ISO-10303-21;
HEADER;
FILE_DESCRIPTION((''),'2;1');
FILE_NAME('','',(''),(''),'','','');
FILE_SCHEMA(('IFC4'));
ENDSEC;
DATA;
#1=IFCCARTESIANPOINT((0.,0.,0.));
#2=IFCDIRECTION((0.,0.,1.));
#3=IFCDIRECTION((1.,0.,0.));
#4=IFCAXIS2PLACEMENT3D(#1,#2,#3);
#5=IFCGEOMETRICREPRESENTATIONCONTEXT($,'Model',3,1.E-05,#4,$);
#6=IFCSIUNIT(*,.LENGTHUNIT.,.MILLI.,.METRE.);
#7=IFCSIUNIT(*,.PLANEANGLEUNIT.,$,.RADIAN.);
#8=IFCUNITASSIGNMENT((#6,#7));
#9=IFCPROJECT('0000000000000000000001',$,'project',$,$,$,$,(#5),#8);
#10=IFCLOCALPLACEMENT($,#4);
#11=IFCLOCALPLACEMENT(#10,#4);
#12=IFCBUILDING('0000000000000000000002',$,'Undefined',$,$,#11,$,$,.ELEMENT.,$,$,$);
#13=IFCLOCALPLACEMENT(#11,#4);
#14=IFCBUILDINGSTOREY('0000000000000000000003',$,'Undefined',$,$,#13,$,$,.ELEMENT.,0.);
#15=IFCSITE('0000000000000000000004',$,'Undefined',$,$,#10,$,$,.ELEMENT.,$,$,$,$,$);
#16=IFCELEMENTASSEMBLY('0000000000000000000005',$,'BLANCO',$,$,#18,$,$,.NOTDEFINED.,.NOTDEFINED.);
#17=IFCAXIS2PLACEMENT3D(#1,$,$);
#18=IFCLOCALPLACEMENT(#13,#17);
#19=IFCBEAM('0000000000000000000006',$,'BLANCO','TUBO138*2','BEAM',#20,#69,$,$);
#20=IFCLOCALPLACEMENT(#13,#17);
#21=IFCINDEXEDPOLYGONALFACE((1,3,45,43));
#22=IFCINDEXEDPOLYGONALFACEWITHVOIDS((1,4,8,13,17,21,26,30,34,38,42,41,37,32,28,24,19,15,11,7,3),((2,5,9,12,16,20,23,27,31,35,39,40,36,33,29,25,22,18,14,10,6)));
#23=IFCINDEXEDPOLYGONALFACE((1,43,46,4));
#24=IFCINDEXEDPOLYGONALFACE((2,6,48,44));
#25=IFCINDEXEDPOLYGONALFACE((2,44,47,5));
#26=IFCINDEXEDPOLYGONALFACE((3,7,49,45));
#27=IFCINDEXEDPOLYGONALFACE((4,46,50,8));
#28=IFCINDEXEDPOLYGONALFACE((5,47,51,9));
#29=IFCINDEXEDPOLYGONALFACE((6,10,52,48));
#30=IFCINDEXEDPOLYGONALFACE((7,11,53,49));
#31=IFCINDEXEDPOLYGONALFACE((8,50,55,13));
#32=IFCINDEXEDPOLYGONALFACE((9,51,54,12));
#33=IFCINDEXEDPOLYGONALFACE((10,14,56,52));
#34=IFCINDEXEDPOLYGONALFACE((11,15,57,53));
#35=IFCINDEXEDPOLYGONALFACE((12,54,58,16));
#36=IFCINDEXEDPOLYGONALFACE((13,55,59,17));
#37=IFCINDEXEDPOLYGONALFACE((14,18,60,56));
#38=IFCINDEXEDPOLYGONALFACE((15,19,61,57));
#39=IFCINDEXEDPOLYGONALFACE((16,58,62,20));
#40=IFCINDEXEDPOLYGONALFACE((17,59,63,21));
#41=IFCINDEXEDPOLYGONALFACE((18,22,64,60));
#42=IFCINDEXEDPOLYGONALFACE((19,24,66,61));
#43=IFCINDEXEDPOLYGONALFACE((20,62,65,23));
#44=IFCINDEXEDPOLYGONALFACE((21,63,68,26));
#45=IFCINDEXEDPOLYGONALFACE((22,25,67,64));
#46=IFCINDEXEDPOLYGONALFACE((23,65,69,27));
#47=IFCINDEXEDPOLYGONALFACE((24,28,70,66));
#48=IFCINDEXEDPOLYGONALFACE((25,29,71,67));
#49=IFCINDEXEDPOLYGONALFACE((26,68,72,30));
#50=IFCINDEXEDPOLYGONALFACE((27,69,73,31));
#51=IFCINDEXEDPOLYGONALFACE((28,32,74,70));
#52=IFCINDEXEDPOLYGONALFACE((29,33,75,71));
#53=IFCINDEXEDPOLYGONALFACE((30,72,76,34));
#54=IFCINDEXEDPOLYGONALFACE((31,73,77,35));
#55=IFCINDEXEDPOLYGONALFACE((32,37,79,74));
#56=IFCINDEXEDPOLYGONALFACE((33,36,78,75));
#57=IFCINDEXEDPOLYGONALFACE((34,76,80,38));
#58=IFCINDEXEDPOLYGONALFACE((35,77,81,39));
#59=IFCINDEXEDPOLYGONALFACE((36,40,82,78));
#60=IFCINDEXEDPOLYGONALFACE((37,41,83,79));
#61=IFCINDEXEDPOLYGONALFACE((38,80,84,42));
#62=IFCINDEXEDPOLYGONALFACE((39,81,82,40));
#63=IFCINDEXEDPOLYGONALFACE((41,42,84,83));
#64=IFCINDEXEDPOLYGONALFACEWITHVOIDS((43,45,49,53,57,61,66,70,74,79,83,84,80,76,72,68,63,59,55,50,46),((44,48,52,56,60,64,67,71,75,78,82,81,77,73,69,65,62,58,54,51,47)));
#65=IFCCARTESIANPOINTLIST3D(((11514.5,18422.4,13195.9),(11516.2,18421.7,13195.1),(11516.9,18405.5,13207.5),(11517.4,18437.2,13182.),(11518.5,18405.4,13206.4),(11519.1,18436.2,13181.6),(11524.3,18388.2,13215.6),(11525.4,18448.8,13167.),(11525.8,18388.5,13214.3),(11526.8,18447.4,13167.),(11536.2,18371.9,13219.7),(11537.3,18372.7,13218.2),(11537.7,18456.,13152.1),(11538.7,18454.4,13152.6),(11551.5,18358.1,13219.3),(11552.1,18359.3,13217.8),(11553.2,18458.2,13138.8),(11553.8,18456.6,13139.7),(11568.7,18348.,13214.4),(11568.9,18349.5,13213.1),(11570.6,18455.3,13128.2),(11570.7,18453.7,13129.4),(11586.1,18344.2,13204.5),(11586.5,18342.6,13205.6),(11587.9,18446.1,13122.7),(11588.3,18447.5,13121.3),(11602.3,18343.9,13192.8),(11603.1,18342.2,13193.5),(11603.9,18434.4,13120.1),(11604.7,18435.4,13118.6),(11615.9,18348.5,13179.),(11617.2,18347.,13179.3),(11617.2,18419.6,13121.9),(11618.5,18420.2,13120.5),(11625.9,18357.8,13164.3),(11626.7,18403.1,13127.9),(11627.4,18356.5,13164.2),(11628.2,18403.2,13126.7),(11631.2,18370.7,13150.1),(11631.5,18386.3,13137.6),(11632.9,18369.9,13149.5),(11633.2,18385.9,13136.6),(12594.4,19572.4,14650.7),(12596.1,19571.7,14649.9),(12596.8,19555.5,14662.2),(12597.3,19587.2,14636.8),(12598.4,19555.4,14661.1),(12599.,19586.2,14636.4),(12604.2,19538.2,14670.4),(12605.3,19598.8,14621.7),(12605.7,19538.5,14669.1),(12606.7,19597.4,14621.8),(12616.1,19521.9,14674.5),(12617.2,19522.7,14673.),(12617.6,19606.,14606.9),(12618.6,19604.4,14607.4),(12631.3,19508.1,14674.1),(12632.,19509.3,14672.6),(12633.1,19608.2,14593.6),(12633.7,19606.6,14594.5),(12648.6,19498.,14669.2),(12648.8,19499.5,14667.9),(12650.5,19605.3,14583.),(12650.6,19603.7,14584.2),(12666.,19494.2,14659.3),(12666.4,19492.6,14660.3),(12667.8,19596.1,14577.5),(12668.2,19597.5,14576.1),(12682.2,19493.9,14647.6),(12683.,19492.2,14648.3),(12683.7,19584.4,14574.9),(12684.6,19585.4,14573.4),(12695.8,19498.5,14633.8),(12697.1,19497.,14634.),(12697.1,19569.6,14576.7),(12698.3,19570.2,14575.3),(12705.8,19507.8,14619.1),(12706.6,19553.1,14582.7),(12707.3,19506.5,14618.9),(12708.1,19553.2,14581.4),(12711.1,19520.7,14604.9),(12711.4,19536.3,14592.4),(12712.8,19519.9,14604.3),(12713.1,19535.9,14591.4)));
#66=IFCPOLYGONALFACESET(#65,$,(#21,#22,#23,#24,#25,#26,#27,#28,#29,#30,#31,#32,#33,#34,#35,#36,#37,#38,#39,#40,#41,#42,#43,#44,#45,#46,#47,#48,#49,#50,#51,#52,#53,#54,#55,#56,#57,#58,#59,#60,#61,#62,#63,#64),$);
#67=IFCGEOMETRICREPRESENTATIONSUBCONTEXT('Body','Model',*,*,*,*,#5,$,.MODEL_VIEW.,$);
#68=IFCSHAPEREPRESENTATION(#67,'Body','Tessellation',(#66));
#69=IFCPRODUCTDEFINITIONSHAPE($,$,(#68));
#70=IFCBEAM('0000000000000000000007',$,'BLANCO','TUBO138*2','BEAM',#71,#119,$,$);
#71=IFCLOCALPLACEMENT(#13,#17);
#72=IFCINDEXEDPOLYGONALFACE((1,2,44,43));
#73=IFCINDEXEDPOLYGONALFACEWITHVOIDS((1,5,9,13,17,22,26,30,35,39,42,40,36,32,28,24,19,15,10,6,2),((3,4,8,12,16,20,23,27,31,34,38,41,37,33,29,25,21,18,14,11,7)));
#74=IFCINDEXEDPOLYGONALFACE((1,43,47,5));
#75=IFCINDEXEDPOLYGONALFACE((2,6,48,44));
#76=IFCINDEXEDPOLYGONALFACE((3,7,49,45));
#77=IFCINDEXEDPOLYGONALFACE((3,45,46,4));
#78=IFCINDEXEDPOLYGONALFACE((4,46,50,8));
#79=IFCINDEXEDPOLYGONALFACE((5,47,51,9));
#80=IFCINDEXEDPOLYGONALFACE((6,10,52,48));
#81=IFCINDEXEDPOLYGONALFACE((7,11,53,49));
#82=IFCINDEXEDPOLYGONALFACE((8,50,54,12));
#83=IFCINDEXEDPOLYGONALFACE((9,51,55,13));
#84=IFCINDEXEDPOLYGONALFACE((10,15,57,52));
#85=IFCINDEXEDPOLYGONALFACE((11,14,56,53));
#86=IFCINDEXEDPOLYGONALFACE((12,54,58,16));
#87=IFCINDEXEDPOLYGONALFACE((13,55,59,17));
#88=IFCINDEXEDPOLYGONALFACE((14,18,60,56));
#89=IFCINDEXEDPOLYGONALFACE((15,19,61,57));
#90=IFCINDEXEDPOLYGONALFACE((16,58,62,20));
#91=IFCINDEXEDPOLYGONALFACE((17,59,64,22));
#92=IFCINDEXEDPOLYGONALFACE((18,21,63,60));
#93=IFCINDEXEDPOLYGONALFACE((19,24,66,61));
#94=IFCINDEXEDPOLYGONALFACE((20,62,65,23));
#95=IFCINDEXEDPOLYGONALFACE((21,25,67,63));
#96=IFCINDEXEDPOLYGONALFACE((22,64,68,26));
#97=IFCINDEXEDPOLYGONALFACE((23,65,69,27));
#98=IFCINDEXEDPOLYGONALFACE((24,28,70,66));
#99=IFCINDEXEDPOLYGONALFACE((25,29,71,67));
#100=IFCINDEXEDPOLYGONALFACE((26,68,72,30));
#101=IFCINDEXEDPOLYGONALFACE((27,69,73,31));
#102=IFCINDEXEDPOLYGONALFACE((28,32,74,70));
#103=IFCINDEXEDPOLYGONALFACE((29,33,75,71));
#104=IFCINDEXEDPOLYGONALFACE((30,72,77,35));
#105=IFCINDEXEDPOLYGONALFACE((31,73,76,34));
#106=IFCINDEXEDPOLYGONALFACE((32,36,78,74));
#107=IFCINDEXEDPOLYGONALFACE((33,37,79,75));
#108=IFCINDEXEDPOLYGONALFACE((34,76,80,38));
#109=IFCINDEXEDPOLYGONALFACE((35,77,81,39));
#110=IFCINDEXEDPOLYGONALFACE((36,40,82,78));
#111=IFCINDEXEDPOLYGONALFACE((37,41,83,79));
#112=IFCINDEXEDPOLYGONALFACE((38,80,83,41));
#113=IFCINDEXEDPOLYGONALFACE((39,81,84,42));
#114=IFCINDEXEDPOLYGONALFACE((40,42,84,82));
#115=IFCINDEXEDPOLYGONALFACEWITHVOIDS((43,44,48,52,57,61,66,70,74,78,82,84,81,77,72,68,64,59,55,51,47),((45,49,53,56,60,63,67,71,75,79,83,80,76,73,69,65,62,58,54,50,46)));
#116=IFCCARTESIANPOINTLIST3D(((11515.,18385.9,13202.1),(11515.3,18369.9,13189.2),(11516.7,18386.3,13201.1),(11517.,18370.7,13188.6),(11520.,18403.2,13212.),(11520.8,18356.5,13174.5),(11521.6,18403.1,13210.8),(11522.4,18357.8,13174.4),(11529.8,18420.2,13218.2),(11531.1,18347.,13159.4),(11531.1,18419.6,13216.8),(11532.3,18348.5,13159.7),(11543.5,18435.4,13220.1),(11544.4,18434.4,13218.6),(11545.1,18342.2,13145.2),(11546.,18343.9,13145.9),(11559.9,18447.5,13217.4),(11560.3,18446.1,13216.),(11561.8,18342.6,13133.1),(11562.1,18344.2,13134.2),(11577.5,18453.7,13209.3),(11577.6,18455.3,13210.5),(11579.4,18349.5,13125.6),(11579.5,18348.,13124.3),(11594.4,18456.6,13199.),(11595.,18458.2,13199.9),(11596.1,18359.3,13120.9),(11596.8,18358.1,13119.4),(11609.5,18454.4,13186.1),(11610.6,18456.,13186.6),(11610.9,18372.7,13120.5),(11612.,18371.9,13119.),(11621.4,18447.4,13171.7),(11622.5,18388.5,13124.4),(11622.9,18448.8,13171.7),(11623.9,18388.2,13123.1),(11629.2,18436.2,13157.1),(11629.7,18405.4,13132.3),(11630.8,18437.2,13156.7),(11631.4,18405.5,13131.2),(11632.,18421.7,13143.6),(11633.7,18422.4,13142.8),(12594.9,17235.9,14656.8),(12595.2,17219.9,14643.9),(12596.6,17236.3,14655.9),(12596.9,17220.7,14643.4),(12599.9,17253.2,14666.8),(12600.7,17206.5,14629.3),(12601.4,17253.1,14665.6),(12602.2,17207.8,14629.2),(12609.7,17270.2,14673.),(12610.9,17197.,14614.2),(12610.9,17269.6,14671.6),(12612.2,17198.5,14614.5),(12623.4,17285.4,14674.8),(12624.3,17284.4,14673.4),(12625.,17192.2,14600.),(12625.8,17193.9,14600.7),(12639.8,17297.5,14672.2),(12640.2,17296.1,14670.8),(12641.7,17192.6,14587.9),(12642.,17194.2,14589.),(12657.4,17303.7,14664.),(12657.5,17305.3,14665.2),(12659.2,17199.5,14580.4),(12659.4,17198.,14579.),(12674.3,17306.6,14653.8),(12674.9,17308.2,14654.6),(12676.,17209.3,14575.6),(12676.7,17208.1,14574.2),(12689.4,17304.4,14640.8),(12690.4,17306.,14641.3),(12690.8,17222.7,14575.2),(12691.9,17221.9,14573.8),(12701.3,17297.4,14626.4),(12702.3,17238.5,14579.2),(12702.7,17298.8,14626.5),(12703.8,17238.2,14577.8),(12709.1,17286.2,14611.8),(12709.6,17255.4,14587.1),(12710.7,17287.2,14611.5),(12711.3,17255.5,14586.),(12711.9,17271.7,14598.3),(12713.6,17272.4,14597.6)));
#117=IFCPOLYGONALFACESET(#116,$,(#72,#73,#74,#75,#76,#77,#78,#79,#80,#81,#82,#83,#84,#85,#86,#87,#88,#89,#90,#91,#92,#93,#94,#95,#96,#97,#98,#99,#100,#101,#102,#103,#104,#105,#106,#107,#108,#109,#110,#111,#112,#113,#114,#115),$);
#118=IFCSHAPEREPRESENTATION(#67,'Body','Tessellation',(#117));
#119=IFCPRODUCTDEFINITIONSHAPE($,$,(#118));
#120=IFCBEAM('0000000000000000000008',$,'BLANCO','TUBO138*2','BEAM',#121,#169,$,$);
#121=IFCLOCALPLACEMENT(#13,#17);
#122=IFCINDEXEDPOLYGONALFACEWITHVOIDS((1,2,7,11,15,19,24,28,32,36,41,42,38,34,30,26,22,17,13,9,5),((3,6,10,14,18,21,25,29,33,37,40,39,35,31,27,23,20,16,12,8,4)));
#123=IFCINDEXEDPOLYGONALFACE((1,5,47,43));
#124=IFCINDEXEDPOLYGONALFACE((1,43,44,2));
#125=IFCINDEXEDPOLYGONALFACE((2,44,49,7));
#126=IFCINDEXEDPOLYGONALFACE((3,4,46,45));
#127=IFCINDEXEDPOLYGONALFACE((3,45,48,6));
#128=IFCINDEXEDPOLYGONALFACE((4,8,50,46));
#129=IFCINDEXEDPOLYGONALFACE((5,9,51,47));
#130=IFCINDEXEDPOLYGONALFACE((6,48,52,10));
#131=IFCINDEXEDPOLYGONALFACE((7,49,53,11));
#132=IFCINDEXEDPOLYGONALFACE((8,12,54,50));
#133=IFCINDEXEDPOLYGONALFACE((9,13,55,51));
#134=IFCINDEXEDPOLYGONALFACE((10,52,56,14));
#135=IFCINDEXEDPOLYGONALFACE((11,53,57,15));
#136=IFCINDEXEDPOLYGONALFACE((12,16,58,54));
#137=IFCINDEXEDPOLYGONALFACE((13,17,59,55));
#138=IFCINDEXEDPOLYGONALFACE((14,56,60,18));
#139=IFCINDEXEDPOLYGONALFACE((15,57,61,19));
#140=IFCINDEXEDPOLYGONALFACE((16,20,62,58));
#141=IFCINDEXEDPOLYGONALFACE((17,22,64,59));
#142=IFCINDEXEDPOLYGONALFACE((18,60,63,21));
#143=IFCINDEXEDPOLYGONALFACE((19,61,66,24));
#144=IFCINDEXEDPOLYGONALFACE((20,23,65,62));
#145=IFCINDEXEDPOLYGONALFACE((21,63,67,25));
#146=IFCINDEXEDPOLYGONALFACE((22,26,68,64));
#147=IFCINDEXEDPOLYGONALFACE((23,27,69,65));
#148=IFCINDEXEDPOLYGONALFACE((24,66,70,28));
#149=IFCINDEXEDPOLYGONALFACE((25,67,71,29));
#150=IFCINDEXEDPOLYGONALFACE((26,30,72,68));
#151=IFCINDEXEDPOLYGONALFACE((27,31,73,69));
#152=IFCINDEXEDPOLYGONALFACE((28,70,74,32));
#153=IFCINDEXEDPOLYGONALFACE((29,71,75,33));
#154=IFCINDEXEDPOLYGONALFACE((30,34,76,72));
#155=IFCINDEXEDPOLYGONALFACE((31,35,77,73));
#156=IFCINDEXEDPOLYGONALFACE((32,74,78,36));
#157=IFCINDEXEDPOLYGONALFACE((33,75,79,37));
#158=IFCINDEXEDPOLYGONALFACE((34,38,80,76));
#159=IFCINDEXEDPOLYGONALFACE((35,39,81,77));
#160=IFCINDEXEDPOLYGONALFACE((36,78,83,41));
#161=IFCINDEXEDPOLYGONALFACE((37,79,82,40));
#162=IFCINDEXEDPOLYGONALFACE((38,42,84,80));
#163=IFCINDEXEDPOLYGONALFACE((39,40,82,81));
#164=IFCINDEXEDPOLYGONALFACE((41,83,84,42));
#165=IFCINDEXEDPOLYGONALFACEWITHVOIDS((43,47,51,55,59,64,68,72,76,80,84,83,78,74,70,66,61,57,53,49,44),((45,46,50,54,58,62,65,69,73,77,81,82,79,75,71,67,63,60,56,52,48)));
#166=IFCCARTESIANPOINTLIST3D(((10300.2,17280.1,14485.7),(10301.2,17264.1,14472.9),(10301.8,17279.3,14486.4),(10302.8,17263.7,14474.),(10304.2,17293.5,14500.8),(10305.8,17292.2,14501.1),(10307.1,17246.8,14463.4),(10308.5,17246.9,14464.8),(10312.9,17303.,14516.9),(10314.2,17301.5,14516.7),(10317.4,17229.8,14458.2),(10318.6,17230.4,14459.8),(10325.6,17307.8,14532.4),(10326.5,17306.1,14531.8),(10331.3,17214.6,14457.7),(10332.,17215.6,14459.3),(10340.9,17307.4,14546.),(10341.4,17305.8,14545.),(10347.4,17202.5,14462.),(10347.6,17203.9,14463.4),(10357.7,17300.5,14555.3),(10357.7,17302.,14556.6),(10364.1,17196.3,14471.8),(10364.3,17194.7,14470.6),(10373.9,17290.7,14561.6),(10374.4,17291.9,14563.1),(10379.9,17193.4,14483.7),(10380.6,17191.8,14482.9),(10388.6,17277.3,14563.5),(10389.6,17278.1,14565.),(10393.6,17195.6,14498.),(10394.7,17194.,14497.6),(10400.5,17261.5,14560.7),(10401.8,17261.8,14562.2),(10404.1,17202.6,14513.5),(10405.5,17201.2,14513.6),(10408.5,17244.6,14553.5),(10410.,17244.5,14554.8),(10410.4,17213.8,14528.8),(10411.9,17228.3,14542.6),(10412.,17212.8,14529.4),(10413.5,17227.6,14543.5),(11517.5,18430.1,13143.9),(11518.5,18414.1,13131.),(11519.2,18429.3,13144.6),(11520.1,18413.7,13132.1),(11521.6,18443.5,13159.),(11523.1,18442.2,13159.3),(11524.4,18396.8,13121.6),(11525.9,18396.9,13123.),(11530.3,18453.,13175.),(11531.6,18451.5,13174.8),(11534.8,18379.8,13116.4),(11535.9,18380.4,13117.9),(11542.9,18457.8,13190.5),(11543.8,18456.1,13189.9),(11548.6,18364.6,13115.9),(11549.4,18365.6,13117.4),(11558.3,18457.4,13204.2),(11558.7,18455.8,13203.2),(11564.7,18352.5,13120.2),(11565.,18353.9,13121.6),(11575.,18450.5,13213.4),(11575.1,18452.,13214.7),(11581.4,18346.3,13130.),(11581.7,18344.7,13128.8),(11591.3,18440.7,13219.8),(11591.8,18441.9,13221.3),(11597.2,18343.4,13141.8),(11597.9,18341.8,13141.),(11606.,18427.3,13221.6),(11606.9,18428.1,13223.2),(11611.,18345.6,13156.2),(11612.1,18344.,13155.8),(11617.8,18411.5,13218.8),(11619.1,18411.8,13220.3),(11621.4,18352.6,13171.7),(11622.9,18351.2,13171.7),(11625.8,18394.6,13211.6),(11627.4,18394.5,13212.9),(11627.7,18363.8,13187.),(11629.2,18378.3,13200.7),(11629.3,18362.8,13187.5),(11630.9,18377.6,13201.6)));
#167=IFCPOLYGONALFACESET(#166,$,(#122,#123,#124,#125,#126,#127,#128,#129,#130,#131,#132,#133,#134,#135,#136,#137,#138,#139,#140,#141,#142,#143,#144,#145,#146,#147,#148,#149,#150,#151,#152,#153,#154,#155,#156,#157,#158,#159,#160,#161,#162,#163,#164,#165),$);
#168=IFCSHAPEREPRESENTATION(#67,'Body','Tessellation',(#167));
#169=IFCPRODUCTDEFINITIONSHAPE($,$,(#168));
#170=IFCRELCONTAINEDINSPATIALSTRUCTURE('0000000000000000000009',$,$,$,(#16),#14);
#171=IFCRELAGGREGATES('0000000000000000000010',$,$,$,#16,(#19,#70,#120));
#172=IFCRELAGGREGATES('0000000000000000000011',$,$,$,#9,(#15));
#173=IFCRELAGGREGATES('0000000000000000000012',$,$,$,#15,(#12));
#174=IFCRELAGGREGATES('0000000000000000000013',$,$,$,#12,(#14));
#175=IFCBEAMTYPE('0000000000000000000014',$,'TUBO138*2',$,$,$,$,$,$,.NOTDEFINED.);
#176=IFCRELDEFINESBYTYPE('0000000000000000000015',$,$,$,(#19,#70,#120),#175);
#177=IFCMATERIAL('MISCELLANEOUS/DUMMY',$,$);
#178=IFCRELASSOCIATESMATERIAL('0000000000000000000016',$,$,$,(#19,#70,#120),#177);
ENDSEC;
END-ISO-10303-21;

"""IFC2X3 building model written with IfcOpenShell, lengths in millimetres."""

from ifc_helpers import new_model, si_unit, frame, origin_with_axes, origin_2d_with_axis, place, context, subcontext, project, spatial, hollow_circle, extrude, material, type_object, element, aggregate, save


model = new_model("IFC2X3")

# Units and contexts
model_context = context("Model", 3, precision=1e-05, world=origin_with_axes())
body_context = subcontext(model_context, "Body", "Model", "MODEL_VIEW")
ifc_project = project(units=[si_unit("LENGTHUNIT", "METRE", prefix="MILLI"), si_unit("PLANEANGLEUNIT", "RADIAN")], contexts=[model_context])

# Site, building, storey
site_placement = place(None, origin_with_axes())
site = spatial("IfcSite", under=ifc_project, at=site_placement, Name="Undefined", CompositionType="ELEMENT")
building_placement = place(site_placement, origin_with_axes())
building = spatial("IfcBuilding", under=site, at=building_placement, Name="Undefined", CompositionType="ELEMENT")
storey_placement = place(building_placement, origin_with_axes())
storey = spatial("IfcBuildingStorey", under=building, at=storey_placement, Name="Undefined", CompositionType="ELEMENT", Elevation=0.0)

# Element assembly, beams
assembly_placement = place(storey_placement, origin_with_axes())
assembly = element("IfcElementAssembly", 1, at=assembly_placement, inside=storey, Name="BLANCO", AssemblyPlace="NOTDEFINED", PredefinedType="NOTDEFINED")
ifc_material = material(Name="MISCELLANEOUS/DUMMY")
beam_type = type_object("IfcBeamType", Name="TUBO138*2", PredefinedType="NOTDEFINED")
beam_1_placement = place(assembly_placement, frame((11574.1, 18400.0, 13169.4), z_axis=(0.497966, 0.461316, -0.734314), x_axis=(0.503224, 0.535899, 0.677922)))
beam_1 = element("IfcBeam", 2, at=beam_1_placement, type_object=beam_type, material=ifc_material, Name="BLANCO", Description="TUBO138*2", ObjectType="BEAM", context=body_context, shape_type="SweptSolid", body=[
    extrude(hollow_circle(Radius=69.0, WallThickness=2.0, at=origin_2d_with_axis()), frame((2145.9, 0.0, 0.0), z_axis=(-1.0, 0.0, 0.0), x_axis=(0.0, -1.0, 0.0)), (0.0, 0.0, 1.0), 2145.9),
])
beam_2_placement = place(assembly_placement, frame((11574.1, 18400.0, 13169.4), z_axis=(0.497966, -0.461316, -0.734314), x_axis=(0.503224, -0.535899, 0.677922)))
beam_2 = element("IfcBeam", 3, at=beam_2_placement, type_object=beam_type, material=ifc_material, Name="BLANCO", Description="TUBO138*2", ObjectType="BEAM", context=body_context, shape_type="SweptSolid", body=[
    extrude(hollow_circle(Radius=69.0, WallThickness=2.0, at=origin_2d_with_axis()), frame((2145.9, 0.0, 0.0), z_axis=(-1.0, 0.0, 0.0), x_axis=(0.0, -1.0, 0.0)), (0.0, 0.0, 1.0), 2145.9),
])
beam_3_placement = place(assembly_placement, frame((11574.1, 18400.0, 13169.4), z_axis=(-0.423552, -0.461316, -0.77961), x_axis=(-0.567282, -0.535899, 0.625303)))
beam_3 = element("IfcBeam", 4, at=beam_3_placement, type_object=beam_type, material=ifc_material, Name="BLANCO", Description="TUBO138*2", ObjectType="BEAM", context=body_context, shape_type="SweptSolid", body=[
    extrude(hollow_circle(Radius=69.0, WallThickness=2.0, at=origin_2d_with_axis()), frame((2145.9, 0.0, 0.0), z_axis=(-1.0, 0.0, 0.0), x_axis=(0.0, -1.0, 0.0)), (0.0, 0.0, 1.0), 2145.9),
])
aggregate(assembly, [beam_1, beam_2, beam_3])

save(model, "model.ifc")
